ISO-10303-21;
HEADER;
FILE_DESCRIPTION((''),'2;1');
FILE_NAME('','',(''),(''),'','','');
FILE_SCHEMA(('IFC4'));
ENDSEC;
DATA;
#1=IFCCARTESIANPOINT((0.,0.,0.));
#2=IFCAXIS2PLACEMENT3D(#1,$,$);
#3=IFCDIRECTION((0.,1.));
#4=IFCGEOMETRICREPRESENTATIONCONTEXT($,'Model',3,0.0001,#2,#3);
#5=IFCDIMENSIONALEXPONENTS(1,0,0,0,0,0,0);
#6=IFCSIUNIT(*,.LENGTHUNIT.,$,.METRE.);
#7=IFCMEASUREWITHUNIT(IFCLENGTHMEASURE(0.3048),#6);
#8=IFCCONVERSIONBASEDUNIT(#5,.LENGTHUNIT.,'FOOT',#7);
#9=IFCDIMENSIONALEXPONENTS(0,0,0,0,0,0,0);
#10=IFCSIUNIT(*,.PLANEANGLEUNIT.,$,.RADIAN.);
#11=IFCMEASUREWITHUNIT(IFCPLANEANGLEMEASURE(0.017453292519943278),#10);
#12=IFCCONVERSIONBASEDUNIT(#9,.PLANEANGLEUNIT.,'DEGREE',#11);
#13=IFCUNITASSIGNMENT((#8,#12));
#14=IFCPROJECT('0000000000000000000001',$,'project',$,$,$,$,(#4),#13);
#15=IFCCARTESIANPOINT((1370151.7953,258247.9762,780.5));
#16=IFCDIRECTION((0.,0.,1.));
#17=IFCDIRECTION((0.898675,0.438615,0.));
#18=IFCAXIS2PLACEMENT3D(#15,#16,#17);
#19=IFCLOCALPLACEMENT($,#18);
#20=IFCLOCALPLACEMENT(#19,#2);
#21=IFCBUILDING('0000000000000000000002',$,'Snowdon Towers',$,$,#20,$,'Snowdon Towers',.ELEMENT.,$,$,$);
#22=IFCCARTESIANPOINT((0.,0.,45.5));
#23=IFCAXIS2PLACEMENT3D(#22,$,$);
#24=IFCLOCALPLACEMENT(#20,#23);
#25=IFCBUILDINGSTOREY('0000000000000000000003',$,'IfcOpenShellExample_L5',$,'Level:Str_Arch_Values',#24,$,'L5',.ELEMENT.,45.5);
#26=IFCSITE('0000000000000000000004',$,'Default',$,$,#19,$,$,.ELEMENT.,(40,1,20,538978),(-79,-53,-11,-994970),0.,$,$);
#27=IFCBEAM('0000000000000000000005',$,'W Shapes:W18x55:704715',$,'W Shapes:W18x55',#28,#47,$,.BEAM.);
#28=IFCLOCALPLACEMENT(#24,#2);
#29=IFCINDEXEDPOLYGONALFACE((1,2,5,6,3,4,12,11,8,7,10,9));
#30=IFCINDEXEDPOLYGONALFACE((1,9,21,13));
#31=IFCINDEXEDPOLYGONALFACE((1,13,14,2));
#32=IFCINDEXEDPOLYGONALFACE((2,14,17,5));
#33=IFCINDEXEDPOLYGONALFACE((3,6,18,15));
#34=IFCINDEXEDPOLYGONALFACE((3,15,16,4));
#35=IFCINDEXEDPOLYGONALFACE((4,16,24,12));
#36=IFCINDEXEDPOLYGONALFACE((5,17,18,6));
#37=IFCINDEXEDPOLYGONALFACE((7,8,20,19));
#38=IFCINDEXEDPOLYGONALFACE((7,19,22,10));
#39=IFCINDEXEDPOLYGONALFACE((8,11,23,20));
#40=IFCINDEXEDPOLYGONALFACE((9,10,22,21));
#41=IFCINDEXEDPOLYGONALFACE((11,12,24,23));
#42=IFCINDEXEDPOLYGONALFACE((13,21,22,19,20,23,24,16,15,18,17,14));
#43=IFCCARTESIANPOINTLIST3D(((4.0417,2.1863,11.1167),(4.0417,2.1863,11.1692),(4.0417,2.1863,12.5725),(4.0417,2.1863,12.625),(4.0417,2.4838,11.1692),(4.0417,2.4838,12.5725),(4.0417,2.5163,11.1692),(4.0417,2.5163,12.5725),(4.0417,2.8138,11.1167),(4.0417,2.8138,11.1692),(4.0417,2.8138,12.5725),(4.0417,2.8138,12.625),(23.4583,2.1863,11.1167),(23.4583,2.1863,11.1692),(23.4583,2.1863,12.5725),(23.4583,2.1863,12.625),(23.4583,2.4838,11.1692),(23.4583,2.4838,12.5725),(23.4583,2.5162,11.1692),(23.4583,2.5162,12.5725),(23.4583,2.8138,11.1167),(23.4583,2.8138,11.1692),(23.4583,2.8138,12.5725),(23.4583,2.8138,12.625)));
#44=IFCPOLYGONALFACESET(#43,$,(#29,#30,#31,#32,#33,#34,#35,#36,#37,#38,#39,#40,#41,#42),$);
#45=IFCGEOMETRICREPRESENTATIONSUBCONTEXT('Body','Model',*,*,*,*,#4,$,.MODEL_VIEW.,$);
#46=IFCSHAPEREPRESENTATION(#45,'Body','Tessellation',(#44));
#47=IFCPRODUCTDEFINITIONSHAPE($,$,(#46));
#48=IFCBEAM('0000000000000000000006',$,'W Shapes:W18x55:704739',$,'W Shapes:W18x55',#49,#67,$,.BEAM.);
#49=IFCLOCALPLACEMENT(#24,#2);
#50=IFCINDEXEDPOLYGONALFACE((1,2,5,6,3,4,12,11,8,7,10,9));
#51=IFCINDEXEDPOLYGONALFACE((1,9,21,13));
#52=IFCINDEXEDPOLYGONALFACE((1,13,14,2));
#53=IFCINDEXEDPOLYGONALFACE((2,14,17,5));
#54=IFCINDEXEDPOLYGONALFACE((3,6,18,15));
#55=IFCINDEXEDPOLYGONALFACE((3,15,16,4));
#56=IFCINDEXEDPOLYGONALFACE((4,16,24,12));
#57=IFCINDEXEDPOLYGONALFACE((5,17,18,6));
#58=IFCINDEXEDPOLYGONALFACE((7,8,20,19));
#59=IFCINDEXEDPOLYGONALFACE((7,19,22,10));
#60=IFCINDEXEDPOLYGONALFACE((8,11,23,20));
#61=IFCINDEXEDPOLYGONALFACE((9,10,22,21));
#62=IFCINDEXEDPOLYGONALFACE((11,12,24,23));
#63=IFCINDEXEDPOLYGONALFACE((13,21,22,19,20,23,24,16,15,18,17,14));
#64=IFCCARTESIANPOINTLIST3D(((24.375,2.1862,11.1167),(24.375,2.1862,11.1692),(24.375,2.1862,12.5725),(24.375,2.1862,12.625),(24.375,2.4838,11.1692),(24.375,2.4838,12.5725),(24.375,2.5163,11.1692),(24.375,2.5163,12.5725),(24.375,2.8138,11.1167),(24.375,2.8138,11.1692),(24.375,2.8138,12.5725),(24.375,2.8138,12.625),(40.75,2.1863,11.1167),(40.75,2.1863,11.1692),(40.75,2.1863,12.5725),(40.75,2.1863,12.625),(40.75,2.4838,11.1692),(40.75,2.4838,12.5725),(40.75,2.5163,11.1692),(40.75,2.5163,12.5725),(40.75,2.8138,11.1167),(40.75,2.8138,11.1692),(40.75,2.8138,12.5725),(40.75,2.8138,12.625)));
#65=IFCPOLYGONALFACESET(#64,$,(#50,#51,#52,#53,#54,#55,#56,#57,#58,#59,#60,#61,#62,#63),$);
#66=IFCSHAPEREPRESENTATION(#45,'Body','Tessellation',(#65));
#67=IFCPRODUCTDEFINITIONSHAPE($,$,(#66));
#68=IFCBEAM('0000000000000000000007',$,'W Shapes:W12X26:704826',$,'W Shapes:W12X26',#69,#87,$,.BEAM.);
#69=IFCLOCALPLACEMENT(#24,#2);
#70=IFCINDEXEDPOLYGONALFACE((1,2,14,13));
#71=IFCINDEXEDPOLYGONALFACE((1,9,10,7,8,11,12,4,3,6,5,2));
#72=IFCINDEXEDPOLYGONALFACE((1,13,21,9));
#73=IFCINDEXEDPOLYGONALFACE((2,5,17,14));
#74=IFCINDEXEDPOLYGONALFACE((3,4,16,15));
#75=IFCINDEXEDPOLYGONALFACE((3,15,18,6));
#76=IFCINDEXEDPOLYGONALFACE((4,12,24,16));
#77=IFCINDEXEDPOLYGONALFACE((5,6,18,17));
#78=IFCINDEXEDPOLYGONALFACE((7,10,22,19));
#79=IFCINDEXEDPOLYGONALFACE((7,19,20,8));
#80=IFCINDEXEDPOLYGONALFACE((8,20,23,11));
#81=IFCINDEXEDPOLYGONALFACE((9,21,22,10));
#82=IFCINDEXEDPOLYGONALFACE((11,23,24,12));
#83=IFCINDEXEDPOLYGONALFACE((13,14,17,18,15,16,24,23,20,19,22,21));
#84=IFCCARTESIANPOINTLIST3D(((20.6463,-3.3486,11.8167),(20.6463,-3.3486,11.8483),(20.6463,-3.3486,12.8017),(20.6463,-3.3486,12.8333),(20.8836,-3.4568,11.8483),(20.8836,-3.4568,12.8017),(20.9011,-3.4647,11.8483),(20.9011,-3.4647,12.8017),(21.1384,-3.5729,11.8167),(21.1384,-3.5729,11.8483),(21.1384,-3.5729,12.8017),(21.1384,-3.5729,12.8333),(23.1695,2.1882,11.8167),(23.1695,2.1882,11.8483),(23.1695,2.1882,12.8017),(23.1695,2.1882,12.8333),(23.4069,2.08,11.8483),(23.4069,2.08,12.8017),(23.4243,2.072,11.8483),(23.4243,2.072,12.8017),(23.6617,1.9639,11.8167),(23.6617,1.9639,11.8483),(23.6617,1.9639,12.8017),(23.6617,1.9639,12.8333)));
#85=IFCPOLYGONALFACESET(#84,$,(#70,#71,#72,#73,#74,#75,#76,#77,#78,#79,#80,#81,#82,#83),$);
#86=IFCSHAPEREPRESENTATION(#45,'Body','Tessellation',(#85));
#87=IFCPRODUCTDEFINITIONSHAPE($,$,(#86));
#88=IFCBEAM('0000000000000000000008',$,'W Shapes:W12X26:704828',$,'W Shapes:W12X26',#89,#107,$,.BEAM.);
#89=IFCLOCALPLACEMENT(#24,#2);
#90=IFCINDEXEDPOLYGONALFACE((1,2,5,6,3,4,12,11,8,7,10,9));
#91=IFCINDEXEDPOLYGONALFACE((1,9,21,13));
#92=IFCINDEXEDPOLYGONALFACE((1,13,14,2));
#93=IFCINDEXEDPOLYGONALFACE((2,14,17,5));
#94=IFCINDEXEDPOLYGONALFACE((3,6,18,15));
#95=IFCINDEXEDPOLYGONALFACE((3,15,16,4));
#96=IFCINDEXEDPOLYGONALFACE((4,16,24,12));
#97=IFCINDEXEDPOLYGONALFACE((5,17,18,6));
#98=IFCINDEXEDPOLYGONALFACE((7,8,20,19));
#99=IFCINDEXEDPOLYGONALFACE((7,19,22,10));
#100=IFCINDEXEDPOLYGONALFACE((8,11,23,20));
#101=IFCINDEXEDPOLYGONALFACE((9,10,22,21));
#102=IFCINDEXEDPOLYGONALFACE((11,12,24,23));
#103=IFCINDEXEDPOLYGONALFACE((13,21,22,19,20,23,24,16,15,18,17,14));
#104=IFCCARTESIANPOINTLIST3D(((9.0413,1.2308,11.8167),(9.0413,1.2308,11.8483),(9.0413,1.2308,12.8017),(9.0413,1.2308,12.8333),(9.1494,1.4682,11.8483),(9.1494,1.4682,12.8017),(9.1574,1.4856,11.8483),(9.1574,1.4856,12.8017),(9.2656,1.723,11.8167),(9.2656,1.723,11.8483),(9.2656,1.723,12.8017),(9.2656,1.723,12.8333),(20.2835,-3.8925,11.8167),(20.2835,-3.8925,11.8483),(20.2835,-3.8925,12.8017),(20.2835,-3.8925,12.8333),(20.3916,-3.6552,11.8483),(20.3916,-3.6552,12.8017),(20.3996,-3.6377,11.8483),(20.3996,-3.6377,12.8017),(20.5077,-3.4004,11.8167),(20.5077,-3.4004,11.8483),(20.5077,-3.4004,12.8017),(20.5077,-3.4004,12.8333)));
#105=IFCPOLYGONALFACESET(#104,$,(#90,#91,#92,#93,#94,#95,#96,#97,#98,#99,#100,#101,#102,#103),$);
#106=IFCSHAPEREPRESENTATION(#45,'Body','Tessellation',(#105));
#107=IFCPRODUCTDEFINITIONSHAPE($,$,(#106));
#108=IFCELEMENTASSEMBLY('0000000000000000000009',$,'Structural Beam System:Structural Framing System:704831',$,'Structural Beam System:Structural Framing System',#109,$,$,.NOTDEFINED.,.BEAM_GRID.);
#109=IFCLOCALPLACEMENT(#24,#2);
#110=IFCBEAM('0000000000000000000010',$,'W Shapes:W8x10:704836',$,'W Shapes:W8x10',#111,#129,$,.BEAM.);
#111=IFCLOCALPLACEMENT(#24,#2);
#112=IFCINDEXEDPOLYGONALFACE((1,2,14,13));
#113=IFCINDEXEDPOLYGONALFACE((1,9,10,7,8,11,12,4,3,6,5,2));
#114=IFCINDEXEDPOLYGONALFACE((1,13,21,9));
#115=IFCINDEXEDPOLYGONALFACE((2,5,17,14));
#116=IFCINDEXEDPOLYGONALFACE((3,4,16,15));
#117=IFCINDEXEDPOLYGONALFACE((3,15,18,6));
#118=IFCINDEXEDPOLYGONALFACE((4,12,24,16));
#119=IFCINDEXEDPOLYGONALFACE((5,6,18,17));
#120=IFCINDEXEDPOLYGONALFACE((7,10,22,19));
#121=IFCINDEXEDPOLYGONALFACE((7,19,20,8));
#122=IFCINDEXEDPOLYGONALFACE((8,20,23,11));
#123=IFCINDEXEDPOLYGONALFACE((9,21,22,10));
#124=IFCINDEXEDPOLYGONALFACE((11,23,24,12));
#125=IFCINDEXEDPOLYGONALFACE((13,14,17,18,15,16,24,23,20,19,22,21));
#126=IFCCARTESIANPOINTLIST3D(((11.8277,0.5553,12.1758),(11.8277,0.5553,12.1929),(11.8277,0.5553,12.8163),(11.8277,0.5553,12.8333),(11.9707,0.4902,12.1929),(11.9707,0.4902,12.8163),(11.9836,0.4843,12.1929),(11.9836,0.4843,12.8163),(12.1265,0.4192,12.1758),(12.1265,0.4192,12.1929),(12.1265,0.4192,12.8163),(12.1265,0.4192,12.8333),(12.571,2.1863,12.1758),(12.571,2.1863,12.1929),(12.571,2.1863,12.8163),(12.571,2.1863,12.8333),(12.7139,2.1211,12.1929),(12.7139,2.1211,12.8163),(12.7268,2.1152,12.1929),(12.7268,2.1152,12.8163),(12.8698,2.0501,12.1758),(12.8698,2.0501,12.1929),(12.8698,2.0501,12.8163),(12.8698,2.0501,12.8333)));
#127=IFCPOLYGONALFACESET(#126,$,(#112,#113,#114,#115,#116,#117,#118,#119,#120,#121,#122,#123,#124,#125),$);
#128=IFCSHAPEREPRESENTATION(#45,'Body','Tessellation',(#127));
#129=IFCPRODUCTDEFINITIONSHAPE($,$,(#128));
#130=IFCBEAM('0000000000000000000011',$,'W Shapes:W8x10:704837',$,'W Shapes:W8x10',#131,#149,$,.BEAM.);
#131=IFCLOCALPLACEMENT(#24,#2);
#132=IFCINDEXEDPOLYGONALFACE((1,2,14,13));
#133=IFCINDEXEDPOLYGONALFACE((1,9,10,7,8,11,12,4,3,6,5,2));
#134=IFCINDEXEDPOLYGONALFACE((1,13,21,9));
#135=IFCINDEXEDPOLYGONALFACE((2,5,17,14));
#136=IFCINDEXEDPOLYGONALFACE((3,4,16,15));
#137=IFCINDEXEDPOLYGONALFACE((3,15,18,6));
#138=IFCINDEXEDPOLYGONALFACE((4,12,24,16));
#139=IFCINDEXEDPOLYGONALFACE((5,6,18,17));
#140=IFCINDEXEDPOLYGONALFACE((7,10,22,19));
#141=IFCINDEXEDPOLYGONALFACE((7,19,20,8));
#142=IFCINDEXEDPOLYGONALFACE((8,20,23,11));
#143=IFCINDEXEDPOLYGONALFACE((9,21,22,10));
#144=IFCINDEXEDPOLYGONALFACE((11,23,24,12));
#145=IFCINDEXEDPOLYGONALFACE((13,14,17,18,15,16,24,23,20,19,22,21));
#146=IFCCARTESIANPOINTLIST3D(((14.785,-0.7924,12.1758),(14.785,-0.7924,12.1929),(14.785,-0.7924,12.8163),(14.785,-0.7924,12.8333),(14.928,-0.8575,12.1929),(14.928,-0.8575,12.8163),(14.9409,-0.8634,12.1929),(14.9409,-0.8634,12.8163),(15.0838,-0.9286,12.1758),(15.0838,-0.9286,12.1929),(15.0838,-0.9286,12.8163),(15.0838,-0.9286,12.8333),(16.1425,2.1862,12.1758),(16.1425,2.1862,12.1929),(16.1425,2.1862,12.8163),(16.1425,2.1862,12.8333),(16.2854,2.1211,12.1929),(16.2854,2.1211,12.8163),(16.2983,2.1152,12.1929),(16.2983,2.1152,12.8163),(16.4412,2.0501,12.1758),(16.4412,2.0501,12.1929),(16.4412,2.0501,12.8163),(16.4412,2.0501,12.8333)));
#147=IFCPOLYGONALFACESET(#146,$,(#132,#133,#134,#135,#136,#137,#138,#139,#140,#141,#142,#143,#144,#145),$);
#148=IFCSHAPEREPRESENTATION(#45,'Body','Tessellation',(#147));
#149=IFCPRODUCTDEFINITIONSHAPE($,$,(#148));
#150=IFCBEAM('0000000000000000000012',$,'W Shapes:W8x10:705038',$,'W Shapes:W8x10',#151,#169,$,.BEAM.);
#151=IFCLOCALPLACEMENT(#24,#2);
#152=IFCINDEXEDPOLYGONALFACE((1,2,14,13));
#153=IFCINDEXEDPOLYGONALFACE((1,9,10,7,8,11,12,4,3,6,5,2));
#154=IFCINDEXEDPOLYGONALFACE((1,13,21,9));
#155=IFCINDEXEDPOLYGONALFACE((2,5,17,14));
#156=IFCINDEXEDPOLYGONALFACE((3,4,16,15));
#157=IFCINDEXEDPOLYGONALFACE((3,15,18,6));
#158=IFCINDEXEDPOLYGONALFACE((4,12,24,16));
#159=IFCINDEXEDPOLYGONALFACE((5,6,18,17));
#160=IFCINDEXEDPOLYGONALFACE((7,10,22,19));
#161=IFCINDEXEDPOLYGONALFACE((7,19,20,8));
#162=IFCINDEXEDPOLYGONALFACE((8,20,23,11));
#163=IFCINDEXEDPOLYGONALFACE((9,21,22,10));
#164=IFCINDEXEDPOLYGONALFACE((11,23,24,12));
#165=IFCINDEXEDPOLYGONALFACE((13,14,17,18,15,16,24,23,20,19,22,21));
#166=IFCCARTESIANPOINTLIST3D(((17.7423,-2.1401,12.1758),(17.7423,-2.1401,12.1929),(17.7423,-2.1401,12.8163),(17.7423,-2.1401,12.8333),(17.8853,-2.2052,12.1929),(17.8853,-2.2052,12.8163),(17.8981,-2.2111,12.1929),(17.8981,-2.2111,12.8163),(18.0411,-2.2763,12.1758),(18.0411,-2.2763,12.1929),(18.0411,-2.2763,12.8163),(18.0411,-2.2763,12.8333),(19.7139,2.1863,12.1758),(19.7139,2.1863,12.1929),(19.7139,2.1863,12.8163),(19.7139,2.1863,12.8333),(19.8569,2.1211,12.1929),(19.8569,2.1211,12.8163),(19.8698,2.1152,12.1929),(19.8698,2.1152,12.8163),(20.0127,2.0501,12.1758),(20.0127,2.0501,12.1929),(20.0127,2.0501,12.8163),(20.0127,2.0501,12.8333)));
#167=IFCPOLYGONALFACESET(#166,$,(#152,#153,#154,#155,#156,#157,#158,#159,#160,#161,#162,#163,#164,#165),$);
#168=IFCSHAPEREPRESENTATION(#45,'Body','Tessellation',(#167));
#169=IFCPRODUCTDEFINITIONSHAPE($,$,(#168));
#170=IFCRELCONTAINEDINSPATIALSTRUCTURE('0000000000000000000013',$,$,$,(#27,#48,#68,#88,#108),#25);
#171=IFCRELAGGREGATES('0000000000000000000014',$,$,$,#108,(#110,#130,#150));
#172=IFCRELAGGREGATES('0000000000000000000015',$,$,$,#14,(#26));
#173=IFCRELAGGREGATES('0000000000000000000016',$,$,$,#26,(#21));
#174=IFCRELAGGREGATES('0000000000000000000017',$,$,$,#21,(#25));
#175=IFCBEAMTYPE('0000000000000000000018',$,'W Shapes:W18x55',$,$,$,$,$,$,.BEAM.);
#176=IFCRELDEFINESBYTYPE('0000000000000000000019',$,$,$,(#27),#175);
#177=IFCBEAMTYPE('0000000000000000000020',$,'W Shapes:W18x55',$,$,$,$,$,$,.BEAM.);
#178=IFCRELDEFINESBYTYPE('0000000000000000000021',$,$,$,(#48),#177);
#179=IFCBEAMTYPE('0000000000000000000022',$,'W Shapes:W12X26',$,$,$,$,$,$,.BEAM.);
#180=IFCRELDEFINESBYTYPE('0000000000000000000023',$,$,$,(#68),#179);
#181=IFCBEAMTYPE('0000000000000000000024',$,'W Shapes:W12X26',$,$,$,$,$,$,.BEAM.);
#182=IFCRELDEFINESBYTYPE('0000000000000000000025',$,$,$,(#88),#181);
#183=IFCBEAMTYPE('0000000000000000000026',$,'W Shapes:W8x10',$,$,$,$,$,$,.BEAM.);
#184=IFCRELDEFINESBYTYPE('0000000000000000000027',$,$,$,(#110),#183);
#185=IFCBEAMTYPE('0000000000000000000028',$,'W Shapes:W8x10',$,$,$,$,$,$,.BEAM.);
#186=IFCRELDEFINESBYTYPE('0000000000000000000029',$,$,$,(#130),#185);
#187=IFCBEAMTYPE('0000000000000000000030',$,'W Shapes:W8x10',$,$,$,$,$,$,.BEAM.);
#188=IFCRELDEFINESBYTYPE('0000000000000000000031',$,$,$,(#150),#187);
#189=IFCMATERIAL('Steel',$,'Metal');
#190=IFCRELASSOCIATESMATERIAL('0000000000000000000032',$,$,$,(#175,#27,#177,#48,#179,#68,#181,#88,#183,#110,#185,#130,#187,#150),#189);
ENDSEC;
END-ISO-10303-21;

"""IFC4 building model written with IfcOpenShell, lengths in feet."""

from ifc_helpers import new_model, entity, si_unit, converted_unit, direction, frame, origin, place, context, subcontext, project, spatial, indexed_curve, outline, extrude, source, transform, mapped, material, type_object, type_shapes, element, aggregate, save


model = new_model("IFC4")

# Units and contexts
model_context = context("Model", 3, precision=0.0001, world=origin(), true_north=direction((0.0, 1.0)))
body_context = subcontext(model_context, "Body", "Model", "MODEL_VIEW")
ifc_project = project(units=[converted_unit("LENGTHUNIT", "FOOT", entity("IfcLengthMeasure", 0.3048), si_unit("LENGTHUNIT", "METRE"), dimensions=[1, 0, 0, 0, 0, 0, 0]), converted_unit("PLANEANGLEUNIT", "DEGREE", entity("IfcPlaneAngleMeasure", 0.017453292519943278), si_unit("PLANEANGLEUNIT", "RADIAN"), dimensions=[0, 0, 0, 0, 0, 0, 0])], contexts=[model_context])

# Site, building, storey
site_placement = place(None, frame((1370151.7953, 258247.9762, 780.5), z_axis=(0.0, 0.0, 1.0), x_axis=(0.898675, 0.438615, 0.0)))
site = spatial("IfcSite", under=ifc_project, at=site_placement, Name="Default", CompositionType="ELEMENT", RefLatitude=(40, 1, 20, 538978), RefLongitude=(-79, -53, -11, -994970), RefElevation=0.0)
building_placement = place(site_placement, origin())
building = spatial("IfcBuilding", under=site, at=building_placement, Name="Snowdon Towers", LongName="Snowdon Towers", CompositionType="ELEMENT")
storey_placement = place(building_placement, frame((0.0, 0.0, 45.5)))
storey = spatial("IfcBuildingStorey", under=building, at=storey_placement, Name="IfcOpenShellExample_L5", ObjectType="Level:Str_Arch_Values", LongName="L5", CompositionType="ELEMENT", Elevation=45.5)

# Beams
ifc_material = material(Name="Steel", Category="Metal")
beam_type_1 = type_object("IfcBeamType", Name="W Shapes:W18x55", PredefinedType="BEAM", material=ifc_material)
shared_shape_1 = source(origin(), body_context, "Body", "SweptSolid", [
    extrude(outline(indexed_curve([(-0.3138, -0.7017), (-0.3138, -0.7542), (0.3138, -0.7542), (0.3138, -0.7017), (0.0162, -0.7017), (0.0162, 0.7017), (0.3138, 0.7017), (0.3138, 0.7542), (-0.3137, 0.7542), (-0.3137, 0.7017), (-0.0163, 0.7017), (-0.0163, -0.7017), (-0.3138, -0.7017)], self_intersect=False)), frame((-9.7917, 0.0, 0.0), z_axis=(-1.0, 0.0, 0.0), x_axis=(0.0, -1.0, 0.0)), (0.0, 0.0, -1.0), 19.4167),
])
type_shapes(beam_type_1, [shared_shape_1])
beam_1_placement = place(storey_placement, frame((13.8333, 2.5, 11.8708)))
element("IfcBeam", 1, at=beam_1_placement, inside=storey, type_object=beam_type_1, material=ifc_material, Name="W Shapes:W18x55:704715", ObjectType="W Shapes:W18x55", PredefinedType="BEAM", context=body_context, shape_type="MappedRepresentation", body=[
    mapped(shared_shape_1, transform((0.0, 0.0, 0.0), scale=1.0)),
])
beam_type_2 = type_object("IfcBeamType", Name="W Shapes:W18x55", PredefinedType="BEAM", material=ifc_material)
shared_shape_2 = source(origin(), body_context, "Body", "SweptSolid", [
    extrude(outline(indexed_curve([(-0.3138, -0.7017), (-0.3138, -0.7542), (0.3138, -0.7542), (0.3138, -0.7017), (0.0162, -0.7017), (0.0162, 0.7017), (0.3138, 0.7017), (0.3138, 0.7542), (-0.3137, 0.7542), (-0.3137, 0.7017), (-0.0163, 0.7017), (-0.0163, -0.7017), (-0.3138, -0.7017)], self_intersect=False)), frame((-7.9583, 0.0, 0.0), z_axis=(-1.0, 0.0, 0.0), x_axis=(0.0, -1.0, 0.0)), (0.0, 0.0, -1.0), 16.375),
])
type_shapes(beam_type_2, [shared_shape_2])
beam_2_placement = place(storey_placement, frame((32.3333, 2.5, 11.8708)))
element("IfcBeam", 2, at=beam_2_placement, inside=storey, type_object=beam_type_2, material=ifc_material, Name="W Shapes:W18x55:704739", ObjectType="W Shapes:W18x55", PredefinedType="BEAM", context=body_context, shape_type="MappedRepresentation", body=[
    mapped(shared_shape_2, transform((0.0, 0.0, 0.0), scale=1.0)),
])
beam_type_3 = type_object("IfcBeamType", Name="W Shapes:W12X26", PredefinedType="BEAM", material=ifc_material)
shared_shape_3 = source(origin(), body_context, "Body", "SweptSolid", [
    extrude(outline(indexed_curve([(-0.2704, -0.4767), (-0.2704, -0.5083), (0.2704, -0.5083), (0.2704, -0.4767), (0.0096, -0.4767), (0.0096, 0.4767), (0.2704, 0.4767), (0.2704, 0.5083), (-0.2704, 0.5083), (-0.2704, 0.4767), (-0.0096, 0.4767), (-0.0096, -0.4767), (-0.2704, -0.4767)], self_intersect=False)), frame((-3.0878, 0.0, 0.0), z_axis=(-1.0, 0.0, 0.0), x_axis=(0.0, -1.0, 0.0)), (0.0, 0.0, -1.0), 6.0846),
])
type_shapes(beam_type_3, [shared_shape_3])
beam_3_placement = place(storey_placement, frame((22.1728, -0.651, 12.325), z_axis=(0.0, 0.0, 1.0), x_axis=(0.414693, 0.909961, 0.0)))
element("IfcBeam", 3, at=beam_3_placement, inside=storey, type_object=beam_type_3, material=ifc_material, Name="W Shapes:W12X26:704826", ObjectType="W Shapes:W12X26", PredefinedType="BEAM", context=body_context, shape_type="MappedRepresentation", body=[
    mapped(shared_shape_3, transform((0.0, 0.0, 0.0), scale=1.0)),
])
beam_type_4 = type_object("IfcBeamType", Name="W Shapes:W12X26", PredefinedType="BEAM", material=ifc_material)
shared_shape_4 = source(origin(), body_context, "Body", "SweptSolid", [
    extrude(outline(indexed_curve([(-0.2704, -0.4767), (-0.2704, -0.5083), (0.2704, -0.5083), (0.2704, -0.4767), (0.0096, -0.4767), (0.0096, 0.4767), (0.2704, 0.4767), (0.2704, 0.5083), (-0.2704, 0.5083), (-0.2704, 0.4767), (-0.0096, 0.4767), (-0.0096, -0.4767), (-0.2704, -0.4767)], self_intersect=False)), frame((-6.2296, 0.0, 0.0), z_axis=(-1.0, 0.0, 0.0), x_axis=(0.0, -1.0, 0.0)), (0.0, 0.0, -1.0), 12.3546),
])
type_shapes(beam_type_4, [shared_shape_4])
beam_4_placement = place(storey_placement, frame((14.8221, -1.1065, 12.325), z_axis=(0.0, 0.0, 1.0), x_axis=(0.909961, -0.414693, 0.0)))
element("IfcBeam", 4, at=beam_4_placement, inside=storey, type_object=beam_type_4, material=ifc_material, Name="W Shapes:W12X26:704828", ObjectType="W Shapes:W12X26", PredefinedType="BEAM", context=body_context, shape_type="MappedRepresentation", body=[
    mapped(shared_shape_4, transform((0.0, 0.0, 0.0), scale=1.0)),
])

# Element assembly, beams
assembly_1_placement = place(storey_placement, origin())
assembly_1 = element("IfcElementAssembly", 5, at=assembly_1_placement, inside=storey, Name="Structural Beam System:Structural Framing System:704831", ObjectType="Structural Beam System:Structural Framing System", AssemblyPlace="NOTDEFINED", PredefinedType="BEAM_GRID")
beam_type_5 = type_object("IfcBeamType", Name="W Shapes:W8x10", PredefinedType="BEAM", material=ifc_material)
shared_shape_5 = source(origin(), body_context, "Body", "SweptSolid", [
    extrude(outline(indexed_curve([(-0.1642, -0.3117), (-0.1642, -0.3288), (0.1642, -0.3288), (0.1642, -0.3117), (0.0071, -0.3117), (0.0071, 0.3117), (0.1642, 0.3117), (0.1642, 0.3287), (-0.1642, 0.3287), (-0.1642, 0.3117), (-0.0071, 0.3117), (-0.0071, -0.3117), (-0.1642, -0.3117)], self_intersect=False)), frame((-0.9708, 0.0, 0.0), z_axis=(-1.0, 0.0, 0.0), x_axis=(0.0, -1.0, 0.0)), (0.0, 0.0, -1.0), 1.7923),
])
type_shapes(beam_type_5, [shared_shape_5])
beam_5_placement = place(assembly_1_placement, frame((12.3797, 1.3706, 12.5046), z_axis=(0.0, 0.0, 1.0), x_axis=(0.414693, 0.909961, 0.0)))
beam_5 = element("IfcBeam", 6, at=beam_5_placement, type_object=beam_type_5, material=ifc_material, Name="W Shapes:W8x10:704836", ObjectType="W Shapes:W8x10", PredefinedType="BEAM", context=body_context, shape_type="MappedRepresentation", body=[
    mapped(shared_shape_5, transform((0.0, 0.0, 0.0), scale=1.0)),
])
beam_type_6 = type_object("IfcBeamType", Name="W Shapes:W8x10", PredefinedType="BEAM", material=ifc_material)
shared_shape_6 = source(origin(), body_context, "Body", "SweptSolid", [
    extrude(outline(indexed_curve([(-0.1642, -0.3117), (-0.1642, -0.3288), (0.1642, -0.3288), (0.1642, -0.3117), (0.0071, -0.3117), (0.0071, 0.3117), (0.1642, 0.3117), (0.1642, 0.3287), (-0.1642, 0.3287), (-0.1642, 0.3117), (-0.0071, 0.3117), (-0.0071, -0.3117), (-0.1642, -0.3117)], self_intersect=False)), frame((-1.7113, 0.0, 0.0), z_axis=(-1.0, 0.0, 0.0), x_axis=(0.0, -1.0, 0.0)), (0.0, 0.0, -1.0), 3.2734),
])
type_shapes(beam_type_6, [shared_shape_6])
beam_6_placement = place(assembly_1_placement, frame((15.6441, 0.6967, 12.5046), z_axis=(0.0, 0.0, 1.0), x_axis=(0.414693, 0.909961, 0.0)))
beam_6 = element("IfcBeam", 7, at=beam_6_placement, type_object=beam_type_6, material=ifc_material, Name="W Shapes:W8x10:704837", ObjectType="W Shapes:W8x10", PredefinedType="BEAM", context=body_context, shape_type="MappedRepresentation", body=[
    mapped(shared_shape_6, transform((0.0, 0.0, 0.0), scale=1.0)),
])
beam_type_7 = type_object("IfcBeamType", Name="W Shapes:W8x10", PredefinedType="BEAM", material=ifc_material)
shared_shape_7 = source(origin(), body_context, "Body", "SweptSolid", [
    extrude(outline(indexed_curve([(-0.1642, -0.3117), (-0.1642, -0.3288), (0.1642, -0.3288), (0.1642, -0.3117), (0.0071, -0.3117), (0.0071, 0.3117), (0.1642, 0.3117), (0.1642, 0.3287), (-0.1642, 0.3287), (-0.1642, 0.3117), (-0.0071, 0.3117), (-0.0071, -0.3117), (-0.1642, -0.3117)], self_intersect=False)), frame((-2.4518, 0.0, 0.0), z_axis=(-1.0, 0.0, 0.0), x_axis=(0.0, -1.0, 0.0)), (0.0, 0.0, -1.0), 4.7544),
])
type_shapes(beam_type_7, [shared_shape_7])
beam_7_placement = place(assembly_1_placement, frame((18.9084, 0.0229, 12.5046), z_axis=(0.0, 0.0, 1.0), x_axis=(0.414693, 0.909961, 0.0)))
beam_7 = element("IfcBeam", 8, at=beam_7_placement, type_object=beam_type_7, material=ifc_material, Name="W Shapes:W8x10:705038", ObjectType="W Shapes:W8x10", PredefinedType="BEAM", context=body_context, shape_type="MappedRepresentation", body=[
    mapped(shared_shape_7, transform((0.0, 0.0, 0.0), scale=1.0)),
])
aggregate(assembly_1, [beam_5, beam_6, beam_7])

save(model, "model.ifc")
